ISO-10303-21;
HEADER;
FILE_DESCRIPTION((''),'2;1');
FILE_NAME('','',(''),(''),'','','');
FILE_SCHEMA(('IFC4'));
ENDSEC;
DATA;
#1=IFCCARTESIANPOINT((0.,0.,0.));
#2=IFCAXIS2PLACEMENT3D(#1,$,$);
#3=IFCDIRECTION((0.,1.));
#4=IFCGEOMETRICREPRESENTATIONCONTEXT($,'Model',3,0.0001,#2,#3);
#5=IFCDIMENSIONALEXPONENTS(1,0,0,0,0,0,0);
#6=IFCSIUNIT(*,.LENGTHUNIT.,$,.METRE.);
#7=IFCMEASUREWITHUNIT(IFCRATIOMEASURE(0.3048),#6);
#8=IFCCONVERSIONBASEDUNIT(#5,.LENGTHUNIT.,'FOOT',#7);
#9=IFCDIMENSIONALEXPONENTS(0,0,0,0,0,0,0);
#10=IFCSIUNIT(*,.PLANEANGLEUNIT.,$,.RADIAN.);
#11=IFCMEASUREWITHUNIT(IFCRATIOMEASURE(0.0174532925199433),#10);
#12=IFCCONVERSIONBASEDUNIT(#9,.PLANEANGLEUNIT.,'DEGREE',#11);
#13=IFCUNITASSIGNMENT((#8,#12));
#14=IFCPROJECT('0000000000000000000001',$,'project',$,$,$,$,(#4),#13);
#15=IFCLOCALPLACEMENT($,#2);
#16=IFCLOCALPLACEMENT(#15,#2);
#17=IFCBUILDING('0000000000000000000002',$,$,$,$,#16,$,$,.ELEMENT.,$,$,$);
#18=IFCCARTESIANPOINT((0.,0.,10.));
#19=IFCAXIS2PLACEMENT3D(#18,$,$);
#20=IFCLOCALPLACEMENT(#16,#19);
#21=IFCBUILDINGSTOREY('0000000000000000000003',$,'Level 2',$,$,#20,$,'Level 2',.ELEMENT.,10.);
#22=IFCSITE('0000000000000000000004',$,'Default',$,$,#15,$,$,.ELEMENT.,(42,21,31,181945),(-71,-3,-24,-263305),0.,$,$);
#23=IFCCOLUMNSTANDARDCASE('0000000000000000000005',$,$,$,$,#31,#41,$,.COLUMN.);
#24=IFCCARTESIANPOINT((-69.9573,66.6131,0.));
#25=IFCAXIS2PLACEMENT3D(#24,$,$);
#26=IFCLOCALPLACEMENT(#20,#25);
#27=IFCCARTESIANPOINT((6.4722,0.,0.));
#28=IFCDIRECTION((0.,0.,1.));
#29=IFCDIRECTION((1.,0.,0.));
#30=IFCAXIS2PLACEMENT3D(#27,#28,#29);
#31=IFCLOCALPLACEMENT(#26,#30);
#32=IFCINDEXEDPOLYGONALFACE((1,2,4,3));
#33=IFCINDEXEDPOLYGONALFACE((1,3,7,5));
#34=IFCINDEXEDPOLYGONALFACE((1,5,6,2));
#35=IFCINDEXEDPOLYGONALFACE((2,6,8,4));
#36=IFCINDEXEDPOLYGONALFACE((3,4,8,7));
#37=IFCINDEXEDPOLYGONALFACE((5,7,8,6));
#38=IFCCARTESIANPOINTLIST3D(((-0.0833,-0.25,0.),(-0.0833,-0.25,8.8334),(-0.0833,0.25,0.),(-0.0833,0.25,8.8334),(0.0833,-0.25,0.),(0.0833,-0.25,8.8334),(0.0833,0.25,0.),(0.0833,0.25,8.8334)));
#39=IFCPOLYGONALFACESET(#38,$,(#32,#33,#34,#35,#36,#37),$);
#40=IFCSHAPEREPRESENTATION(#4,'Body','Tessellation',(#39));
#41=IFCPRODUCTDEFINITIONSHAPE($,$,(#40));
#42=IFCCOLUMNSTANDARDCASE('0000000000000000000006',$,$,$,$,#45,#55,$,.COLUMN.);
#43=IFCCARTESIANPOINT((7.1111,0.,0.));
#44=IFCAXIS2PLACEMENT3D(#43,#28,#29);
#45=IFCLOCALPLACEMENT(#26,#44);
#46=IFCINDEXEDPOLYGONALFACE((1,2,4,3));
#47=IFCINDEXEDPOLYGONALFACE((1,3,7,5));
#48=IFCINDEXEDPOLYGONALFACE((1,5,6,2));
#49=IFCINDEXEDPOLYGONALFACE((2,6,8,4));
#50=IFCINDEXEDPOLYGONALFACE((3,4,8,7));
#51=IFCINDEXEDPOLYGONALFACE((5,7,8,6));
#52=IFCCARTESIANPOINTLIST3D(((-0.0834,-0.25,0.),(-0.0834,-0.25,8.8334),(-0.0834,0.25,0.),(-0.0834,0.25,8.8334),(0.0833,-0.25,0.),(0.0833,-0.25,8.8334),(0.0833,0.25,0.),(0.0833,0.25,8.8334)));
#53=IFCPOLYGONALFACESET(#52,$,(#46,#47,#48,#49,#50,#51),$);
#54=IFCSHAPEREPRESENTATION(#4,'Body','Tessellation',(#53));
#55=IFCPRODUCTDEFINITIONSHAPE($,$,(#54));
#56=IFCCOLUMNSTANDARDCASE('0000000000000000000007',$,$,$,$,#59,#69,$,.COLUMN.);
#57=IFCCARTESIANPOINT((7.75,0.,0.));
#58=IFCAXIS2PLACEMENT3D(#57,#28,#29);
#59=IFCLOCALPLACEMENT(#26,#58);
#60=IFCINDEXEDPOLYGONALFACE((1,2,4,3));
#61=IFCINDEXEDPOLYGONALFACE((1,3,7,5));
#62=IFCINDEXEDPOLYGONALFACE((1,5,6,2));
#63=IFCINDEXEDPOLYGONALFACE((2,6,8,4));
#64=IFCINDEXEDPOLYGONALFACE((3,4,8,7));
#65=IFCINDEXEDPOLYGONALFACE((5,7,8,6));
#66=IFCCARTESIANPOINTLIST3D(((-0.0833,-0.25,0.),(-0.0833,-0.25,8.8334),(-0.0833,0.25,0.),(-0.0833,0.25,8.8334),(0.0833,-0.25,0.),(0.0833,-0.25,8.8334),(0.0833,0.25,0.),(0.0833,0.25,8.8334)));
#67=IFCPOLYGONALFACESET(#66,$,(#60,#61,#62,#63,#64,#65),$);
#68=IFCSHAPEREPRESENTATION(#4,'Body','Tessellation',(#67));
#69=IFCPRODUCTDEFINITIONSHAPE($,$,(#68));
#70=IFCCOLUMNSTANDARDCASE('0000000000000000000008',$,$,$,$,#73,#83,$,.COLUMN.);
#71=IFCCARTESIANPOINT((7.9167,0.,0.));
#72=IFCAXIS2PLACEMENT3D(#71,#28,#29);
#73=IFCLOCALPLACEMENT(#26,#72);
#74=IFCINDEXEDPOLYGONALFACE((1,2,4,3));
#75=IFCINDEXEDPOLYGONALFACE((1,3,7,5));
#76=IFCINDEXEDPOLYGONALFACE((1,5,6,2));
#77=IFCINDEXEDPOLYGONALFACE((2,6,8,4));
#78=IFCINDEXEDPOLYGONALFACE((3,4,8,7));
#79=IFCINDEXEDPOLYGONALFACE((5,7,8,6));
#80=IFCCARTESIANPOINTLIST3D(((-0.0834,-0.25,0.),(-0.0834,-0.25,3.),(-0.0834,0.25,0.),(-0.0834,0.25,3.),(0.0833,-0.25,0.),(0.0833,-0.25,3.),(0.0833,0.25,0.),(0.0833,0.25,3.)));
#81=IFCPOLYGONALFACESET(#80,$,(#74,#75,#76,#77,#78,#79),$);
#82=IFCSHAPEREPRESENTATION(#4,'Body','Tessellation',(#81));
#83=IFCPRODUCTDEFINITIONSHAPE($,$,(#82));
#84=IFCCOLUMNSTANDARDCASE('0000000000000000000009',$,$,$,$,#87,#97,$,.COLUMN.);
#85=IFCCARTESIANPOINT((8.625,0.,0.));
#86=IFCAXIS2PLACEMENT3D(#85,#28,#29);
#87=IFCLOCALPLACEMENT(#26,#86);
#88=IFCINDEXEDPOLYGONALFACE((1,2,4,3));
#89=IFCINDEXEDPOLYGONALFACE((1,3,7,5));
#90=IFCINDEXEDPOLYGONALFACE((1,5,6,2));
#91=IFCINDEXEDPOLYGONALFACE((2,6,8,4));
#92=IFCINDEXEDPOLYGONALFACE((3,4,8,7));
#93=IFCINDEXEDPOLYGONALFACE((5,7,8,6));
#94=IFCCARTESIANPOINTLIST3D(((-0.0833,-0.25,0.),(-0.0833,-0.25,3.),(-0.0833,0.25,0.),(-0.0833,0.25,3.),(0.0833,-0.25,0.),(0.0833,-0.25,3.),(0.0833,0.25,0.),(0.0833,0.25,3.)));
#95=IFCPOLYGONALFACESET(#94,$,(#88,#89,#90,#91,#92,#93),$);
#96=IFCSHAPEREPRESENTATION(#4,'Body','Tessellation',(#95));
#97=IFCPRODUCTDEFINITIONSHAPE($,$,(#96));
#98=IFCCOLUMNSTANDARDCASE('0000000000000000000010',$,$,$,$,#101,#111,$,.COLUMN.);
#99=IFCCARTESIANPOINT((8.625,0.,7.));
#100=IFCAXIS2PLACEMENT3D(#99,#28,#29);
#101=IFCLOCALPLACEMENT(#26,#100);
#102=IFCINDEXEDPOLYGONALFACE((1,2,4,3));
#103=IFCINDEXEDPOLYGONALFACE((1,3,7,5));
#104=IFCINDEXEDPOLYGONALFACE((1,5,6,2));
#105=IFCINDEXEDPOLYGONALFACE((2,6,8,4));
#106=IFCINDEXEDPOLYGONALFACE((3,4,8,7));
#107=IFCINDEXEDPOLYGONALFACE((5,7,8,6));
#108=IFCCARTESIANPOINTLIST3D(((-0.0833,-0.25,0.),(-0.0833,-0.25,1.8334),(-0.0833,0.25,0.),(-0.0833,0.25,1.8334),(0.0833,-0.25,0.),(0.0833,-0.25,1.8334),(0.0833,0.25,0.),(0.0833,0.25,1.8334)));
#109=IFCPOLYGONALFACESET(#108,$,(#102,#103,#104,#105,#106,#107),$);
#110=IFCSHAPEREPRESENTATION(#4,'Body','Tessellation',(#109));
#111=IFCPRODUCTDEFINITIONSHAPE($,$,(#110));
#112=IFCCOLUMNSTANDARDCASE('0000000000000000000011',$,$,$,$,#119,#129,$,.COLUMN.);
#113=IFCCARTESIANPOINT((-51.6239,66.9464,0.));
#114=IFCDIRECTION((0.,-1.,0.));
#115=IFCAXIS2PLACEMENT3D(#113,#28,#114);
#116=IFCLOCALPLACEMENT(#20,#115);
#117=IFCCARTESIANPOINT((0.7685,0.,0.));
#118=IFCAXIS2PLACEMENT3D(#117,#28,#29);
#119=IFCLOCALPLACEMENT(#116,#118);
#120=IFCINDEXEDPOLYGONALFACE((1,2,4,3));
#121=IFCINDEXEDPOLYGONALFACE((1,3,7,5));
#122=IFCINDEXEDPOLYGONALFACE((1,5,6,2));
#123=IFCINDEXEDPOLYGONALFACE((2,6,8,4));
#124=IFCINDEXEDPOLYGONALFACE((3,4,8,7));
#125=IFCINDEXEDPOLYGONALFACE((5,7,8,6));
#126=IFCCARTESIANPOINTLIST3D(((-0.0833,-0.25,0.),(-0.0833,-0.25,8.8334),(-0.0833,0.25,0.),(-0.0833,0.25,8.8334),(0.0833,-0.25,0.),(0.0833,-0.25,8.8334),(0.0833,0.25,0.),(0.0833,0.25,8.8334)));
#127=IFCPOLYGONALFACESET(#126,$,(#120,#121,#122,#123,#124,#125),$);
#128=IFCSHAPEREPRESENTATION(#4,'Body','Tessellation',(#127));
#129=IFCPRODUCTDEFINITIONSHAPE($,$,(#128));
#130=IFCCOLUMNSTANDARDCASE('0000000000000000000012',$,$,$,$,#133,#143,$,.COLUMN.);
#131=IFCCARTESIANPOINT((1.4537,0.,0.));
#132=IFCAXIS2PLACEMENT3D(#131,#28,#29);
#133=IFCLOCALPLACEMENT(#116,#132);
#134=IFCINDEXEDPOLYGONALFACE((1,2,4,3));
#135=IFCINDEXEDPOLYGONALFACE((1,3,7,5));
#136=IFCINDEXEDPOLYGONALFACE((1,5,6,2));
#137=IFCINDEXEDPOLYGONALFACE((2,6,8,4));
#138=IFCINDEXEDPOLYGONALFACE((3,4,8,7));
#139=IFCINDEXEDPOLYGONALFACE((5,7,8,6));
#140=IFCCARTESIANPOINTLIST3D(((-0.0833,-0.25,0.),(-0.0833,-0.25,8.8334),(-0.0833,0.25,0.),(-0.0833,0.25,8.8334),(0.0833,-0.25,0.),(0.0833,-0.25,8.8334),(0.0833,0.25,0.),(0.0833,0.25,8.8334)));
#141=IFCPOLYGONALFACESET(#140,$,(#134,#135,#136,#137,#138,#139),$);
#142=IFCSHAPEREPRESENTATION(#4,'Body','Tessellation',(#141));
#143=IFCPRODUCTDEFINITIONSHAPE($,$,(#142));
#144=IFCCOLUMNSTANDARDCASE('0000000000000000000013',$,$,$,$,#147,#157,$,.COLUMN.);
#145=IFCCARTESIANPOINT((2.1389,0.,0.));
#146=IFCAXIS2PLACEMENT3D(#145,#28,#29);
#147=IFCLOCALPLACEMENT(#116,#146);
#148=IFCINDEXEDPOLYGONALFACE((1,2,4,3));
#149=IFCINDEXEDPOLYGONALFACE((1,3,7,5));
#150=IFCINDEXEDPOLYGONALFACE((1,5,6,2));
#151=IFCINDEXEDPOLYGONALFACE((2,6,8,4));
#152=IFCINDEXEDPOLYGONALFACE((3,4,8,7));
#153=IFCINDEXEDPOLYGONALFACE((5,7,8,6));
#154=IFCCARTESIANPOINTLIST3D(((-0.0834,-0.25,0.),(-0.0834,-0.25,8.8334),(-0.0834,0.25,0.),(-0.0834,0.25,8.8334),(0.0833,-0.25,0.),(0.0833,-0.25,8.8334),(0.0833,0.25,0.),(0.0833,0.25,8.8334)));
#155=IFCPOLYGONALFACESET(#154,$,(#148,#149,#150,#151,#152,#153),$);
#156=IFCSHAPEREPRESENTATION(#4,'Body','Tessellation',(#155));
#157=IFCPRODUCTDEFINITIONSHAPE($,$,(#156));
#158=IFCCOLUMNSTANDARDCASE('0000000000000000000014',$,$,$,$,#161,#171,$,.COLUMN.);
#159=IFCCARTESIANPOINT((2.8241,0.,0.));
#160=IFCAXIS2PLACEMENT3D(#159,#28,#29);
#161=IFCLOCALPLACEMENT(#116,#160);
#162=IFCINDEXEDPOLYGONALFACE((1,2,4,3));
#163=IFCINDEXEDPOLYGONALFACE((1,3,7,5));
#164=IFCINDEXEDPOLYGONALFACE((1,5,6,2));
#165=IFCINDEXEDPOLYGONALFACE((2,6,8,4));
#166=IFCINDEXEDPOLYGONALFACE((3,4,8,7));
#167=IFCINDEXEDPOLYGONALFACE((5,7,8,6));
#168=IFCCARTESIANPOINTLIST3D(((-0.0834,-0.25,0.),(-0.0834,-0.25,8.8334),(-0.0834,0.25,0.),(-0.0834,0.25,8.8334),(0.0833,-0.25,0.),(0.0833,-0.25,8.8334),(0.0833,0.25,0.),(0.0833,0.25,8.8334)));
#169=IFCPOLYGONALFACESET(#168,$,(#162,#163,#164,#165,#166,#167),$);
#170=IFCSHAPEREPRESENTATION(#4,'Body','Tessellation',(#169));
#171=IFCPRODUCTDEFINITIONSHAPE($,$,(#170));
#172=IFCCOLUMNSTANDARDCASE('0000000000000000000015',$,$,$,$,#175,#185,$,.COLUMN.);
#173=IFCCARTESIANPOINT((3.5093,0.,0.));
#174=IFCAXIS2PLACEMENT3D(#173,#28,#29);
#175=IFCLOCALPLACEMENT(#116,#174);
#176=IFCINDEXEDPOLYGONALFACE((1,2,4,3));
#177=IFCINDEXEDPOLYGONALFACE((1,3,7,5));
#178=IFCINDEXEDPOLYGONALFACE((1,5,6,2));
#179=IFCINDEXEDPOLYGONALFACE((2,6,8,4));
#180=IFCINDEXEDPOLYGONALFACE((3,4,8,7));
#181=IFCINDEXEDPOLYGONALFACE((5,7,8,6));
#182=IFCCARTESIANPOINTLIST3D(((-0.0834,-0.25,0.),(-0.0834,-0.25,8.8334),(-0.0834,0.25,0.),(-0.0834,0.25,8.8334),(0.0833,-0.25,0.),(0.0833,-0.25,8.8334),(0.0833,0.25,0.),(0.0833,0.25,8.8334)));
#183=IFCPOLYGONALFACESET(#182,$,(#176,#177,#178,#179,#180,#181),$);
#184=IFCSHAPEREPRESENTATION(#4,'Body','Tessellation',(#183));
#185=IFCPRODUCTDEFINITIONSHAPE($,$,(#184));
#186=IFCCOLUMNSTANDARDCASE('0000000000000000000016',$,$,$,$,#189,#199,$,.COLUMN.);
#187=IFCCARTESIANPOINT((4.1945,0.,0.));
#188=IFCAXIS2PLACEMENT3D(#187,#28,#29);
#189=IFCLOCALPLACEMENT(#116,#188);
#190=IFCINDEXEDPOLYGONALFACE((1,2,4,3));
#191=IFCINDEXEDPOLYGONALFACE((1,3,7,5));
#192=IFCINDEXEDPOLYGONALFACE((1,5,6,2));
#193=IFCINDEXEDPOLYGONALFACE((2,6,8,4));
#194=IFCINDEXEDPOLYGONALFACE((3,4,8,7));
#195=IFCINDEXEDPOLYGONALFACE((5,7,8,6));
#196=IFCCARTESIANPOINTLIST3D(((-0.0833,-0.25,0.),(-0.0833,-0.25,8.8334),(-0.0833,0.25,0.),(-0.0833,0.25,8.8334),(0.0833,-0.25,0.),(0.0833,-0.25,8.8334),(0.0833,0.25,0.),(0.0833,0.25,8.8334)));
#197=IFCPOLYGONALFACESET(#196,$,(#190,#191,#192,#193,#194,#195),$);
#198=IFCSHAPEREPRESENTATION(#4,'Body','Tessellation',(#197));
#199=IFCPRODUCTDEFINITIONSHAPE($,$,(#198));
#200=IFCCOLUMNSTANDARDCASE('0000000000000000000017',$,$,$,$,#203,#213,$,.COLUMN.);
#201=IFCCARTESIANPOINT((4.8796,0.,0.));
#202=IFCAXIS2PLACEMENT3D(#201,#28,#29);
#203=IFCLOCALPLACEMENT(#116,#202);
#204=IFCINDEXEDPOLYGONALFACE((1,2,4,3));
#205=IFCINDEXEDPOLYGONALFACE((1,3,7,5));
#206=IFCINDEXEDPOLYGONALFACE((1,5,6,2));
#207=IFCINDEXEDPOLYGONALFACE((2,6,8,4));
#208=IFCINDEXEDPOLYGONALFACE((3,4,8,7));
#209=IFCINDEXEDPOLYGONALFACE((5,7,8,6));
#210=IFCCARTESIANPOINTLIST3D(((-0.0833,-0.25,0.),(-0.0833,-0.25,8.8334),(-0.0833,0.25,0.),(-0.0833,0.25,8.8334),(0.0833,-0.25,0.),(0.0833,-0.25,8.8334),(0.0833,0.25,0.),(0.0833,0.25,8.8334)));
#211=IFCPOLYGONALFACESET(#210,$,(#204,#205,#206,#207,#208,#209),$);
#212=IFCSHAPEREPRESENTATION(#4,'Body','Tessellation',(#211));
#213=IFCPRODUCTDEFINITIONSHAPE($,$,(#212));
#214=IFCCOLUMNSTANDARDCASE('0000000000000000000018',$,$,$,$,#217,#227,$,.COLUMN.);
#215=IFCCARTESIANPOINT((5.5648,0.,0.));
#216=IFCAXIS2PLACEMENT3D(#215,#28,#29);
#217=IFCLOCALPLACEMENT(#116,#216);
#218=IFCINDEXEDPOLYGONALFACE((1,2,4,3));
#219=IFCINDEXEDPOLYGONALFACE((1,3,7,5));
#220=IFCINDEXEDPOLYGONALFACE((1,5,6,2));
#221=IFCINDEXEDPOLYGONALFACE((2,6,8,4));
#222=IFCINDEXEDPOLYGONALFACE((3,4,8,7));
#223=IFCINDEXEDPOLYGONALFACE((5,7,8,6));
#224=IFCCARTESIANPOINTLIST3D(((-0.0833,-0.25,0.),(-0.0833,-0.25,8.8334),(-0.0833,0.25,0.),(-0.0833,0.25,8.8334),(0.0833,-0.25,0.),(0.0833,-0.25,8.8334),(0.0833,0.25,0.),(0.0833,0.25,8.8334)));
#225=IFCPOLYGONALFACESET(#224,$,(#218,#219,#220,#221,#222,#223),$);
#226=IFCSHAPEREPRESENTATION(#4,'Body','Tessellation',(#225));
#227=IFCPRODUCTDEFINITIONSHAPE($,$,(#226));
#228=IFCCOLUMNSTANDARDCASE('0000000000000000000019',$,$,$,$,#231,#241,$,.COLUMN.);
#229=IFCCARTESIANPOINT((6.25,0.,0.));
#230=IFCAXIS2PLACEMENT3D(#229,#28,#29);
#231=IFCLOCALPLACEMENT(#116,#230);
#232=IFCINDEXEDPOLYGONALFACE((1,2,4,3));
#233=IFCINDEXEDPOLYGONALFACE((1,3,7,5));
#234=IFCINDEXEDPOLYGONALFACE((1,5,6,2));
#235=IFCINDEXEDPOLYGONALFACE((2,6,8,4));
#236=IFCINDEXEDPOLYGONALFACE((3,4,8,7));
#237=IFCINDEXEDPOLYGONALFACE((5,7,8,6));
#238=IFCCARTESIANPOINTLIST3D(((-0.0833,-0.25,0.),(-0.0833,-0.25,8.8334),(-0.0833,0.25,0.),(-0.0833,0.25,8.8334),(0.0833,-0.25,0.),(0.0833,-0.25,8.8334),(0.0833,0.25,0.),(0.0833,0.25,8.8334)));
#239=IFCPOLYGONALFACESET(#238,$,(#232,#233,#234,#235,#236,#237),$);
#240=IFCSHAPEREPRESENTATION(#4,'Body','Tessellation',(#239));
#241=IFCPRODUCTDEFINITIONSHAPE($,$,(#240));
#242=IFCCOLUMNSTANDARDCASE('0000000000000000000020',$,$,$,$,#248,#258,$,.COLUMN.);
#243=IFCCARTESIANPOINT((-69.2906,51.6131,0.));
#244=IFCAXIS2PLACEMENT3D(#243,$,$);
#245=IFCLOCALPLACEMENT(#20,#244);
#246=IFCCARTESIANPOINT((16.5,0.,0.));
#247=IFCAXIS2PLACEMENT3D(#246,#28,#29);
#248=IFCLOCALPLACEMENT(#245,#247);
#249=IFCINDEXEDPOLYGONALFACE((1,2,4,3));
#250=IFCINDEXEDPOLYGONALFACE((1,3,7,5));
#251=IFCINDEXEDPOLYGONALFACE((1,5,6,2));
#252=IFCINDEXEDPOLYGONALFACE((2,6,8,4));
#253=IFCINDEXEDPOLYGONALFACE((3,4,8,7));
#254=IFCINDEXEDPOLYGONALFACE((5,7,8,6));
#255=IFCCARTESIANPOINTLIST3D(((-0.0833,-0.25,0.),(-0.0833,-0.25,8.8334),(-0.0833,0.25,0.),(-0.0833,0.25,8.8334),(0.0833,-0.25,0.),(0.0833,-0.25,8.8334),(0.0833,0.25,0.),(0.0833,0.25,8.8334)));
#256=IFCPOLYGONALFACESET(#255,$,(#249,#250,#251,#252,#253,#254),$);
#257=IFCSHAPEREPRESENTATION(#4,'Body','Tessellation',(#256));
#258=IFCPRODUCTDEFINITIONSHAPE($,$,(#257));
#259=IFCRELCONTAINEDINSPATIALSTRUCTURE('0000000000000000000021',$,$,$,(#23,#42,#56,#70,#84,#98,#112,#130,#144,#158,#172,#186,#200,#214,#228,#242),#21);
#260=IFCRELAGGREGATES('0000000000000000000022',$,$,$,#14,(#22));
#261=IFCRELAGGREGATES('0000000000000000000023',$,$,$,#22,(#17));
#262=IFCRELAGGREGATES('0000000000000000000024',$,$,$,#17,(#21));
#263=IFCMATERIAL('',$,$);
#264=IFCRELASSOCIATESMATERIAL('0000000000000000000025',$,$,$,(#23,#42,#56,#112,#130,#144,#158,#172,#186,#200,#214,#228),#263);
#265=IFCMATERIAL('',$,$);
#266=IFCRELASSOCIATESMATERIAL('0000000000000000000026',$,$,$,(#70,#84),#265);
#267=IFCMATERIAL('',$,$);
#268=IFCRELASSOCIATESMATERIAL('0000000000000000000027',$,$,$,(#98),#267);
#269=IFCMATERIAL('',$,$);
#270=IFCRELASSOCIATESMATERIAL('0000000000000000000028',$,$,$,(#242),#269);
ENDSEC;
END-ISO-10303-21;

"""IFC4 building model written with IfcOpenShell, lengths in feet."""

from ifc_helpers import new_model, entity, si_unit, converted_unit, direction, frame, origin, place, context, project, spatial, rectangle, extrude, material, element, save


model = new_model("IFC4")

# Units and contexts
model_context = context("Model", 3, precision=0.0001, world=origin(), true_north=direction((0.0, 1.0)))
ifc_project = project(units=[converted_unit("LENGTHUNIT", "FOOT", entity("IfcRatioMeasure", 0.3048), si_unit("LENGTHUNIT", "METRE"), dimensions=[1, 0, 0, 0, 0, 0, 0]), converted_unit("PLANEANGLEUNIT", "DEGREE", entity("IfcRatioMeasure", 0.0174532925199433), si_unit("PLANEANGLEUNIT", "RADIAN"), dimensions=[0, 0, 0, 0, 0, 0, 0])], contexts=[model_context])

# Site, building, storey
site_placement = place(None, origin())
site = spatial("IfcSite", under=ifc_project, at=site_placement, Name="Default", CompositionType="ELEMENT", RefLatitude=(42, 21, 31, 181945), RefLongitude=(-71, -3, -24, -263305), RefElevation=0.0)
building_placement = place(site_placement, origin())
building = spatial("IfcBuilding", under=site, at=building_placement, CompositionType="ELEMENT")
storey_placement = place(building_placement, frame((0.0, 0.0, 10.0)))
storey = spatial("IfcBuildingStorey", under=building, at=storey_placement, Name="Level 2", LongName="Level 2", CompositionType="ELEMENT", Elevation=10.0)

# Columns
ifc_material_1 = material(Name="")
placement_1 = place(storey_placement, frame((-69.9573, 66.6131, 0.0)))
for number, where, z_axis, x_axis in (
    (1, (6.4722, 0.0, 0.0), (0.0, 0.0, 1.0), (1.0, 0.0, 0.0)),
    (2, (7.1111, 0.0, 0.0), (0.0, 0.0, 1.0), (1.0, 0.0, 0.0)),
    (3, (7.75, 0.0, 0.0), (0.0, 0.0, 1.0), (1.0, 0.0, 0.0)),
):
    element("IfcColumnStandardCase", number, at=place(placement_1, frame(where, z_axis=z_axis, x_axis=x_axis)), inside=storey, material=ifc_material_1, PredefinedType="COLUMN", context=model_context, shape_type="SweptSolid", body=[
        extrude(rectangle(XDim=0.1667, YDim=0.5), origin(), (0.0, 0.0, 1.0), 8.8334),
    ])
ifc_material_2 = material(Name="")
for number, where, z_axis, x_axis in (
    (4, (7.9167, 0.0, 0.0), (0.0, 0.0, 1.0), (1.0, 0.0, 0.0)),
    (5, (8.625, 0.0, 0.0), (0.0, 0.0, 1.0), (1.0, 0.0, 0.0)),
):
    element("IfcColumnStandardCase", number, at=place(placement_1, frame(where, z_axis=z_axis, x_axis=x_axis)), inside=storey, material=ifc_material_2, PredefinedType="COLUMN", context=model_context, shape_type="SweptSolid", body=[
        extrude(rectangle(XDim=0.1667, YDim=0.5), origin(), (0.0, 0.0, 1.0), 3.0),
    ])
ifc_material_3 = material(Name="")
for number, where, z_axis, x_axis in (
    (6, (8.625, 0.0, 7.0), (0.0, 0.0, 1.0), (1.0, 0.0, 0.0)),
):
    element("IfcColumnStandardCase", number, at=place(placement_1, frame(where, z_axis=z_axis, x_axis=x_axis)), inside=storey, material=ifc_material_3, PredefinedType="COLUMN", context=model_context, shape_type="SweptSolid", body=[
        extrude(rectangle(XDim=0.1667, YDim=0.5), origin(), (0.0, 0.0, 1.0), 1.8334),
    ])
placement_2 = place(storey_placement, frame((-51.6239, 66.9464, 0.0), z_axis=(0.0, 0.0, 1.0), x_axis=(0.0, -1.0, 0.0)))
for number, where, z_axis, x_axis in (
    (7, (0.7685, 0.0, 0.0), (0.0, 0.0, 1.0), (1.0, 0.0, 0.0)),
    (8, (1.4537, 0.0, 0.0), (0.0, 0.0, 1.0), (1.0, 0.0, 0.0)),
    (9, (2.1389, 0.0, 0.0), (0.0, 0.0, 1.0), (1.0, 0.0, 0.0)),
    (10, (2.8241, 0.0, 0.0), (0.0, 0.0, 1.0), (1.0, 0.0, 0.0)),
    (11, (3.5093, 0.0, 0.0), (0.0, 0.0, 1.0), (1.0, 0.0, 0.0)),
    (12, (4.1945, 0.0, 0.0), (0.0, 0.0, 1.0), (1.0, 0.0, 0.0)),
    (13, (4.8796, 0.0, 0.0), (0.0, 0.0, 1.0), (1.0, 0.0, 0.0)),
    (14, (5.5648, 0.0, 0.0), (0.0, 0.0, 1.0), (1.0, 0.0, 0.0)),
    (15, (6.25, 0.0, 0.0), (0.0, 0.0, 1.0), (1.0, 0.0, 0.0)),
):
    element("IfcColumnStandardCase", number, at=place(placement_2, frame(where, z_axis=z_axis, x_axis=x_axis)), inside=storey, material=ifc_material_1, PredefinedType="COLUMN", context=model_context, shape_type="SweptSolid", body=[
        extrude(rectangle(XDim=0.1667, YDim=0.5), origin(), (0.0, 0.0, 1.0), 8.8334),
    ])
ifc_material_4 = material(Name="")
placement_3 = place(storey_placement, frame((-69.2906, 51.6131, 0.0)))
for number, where, z_axis, x_axis in (
    (16, (16.5, 0.0, 0.0), (0.0, 0.0, 1.0), (1.0, 0.0, 0.0)),
):
    element("IfcColumnStandardCase", number, at=place(placement_3, frame(where, z_axis=z_axis, x_axis=x_axis)), inside=storey, material=ifc_material_4, PredefinedType="COLUMN", context=model_context, shape_type="SweptSolid", body=[
        extrude(rectangle(XDim=0.1667, YDim=0.5), origin(), (0.0, 0.0, 1.0), 8.8334),
    ])

save(model, "model.ifc")
